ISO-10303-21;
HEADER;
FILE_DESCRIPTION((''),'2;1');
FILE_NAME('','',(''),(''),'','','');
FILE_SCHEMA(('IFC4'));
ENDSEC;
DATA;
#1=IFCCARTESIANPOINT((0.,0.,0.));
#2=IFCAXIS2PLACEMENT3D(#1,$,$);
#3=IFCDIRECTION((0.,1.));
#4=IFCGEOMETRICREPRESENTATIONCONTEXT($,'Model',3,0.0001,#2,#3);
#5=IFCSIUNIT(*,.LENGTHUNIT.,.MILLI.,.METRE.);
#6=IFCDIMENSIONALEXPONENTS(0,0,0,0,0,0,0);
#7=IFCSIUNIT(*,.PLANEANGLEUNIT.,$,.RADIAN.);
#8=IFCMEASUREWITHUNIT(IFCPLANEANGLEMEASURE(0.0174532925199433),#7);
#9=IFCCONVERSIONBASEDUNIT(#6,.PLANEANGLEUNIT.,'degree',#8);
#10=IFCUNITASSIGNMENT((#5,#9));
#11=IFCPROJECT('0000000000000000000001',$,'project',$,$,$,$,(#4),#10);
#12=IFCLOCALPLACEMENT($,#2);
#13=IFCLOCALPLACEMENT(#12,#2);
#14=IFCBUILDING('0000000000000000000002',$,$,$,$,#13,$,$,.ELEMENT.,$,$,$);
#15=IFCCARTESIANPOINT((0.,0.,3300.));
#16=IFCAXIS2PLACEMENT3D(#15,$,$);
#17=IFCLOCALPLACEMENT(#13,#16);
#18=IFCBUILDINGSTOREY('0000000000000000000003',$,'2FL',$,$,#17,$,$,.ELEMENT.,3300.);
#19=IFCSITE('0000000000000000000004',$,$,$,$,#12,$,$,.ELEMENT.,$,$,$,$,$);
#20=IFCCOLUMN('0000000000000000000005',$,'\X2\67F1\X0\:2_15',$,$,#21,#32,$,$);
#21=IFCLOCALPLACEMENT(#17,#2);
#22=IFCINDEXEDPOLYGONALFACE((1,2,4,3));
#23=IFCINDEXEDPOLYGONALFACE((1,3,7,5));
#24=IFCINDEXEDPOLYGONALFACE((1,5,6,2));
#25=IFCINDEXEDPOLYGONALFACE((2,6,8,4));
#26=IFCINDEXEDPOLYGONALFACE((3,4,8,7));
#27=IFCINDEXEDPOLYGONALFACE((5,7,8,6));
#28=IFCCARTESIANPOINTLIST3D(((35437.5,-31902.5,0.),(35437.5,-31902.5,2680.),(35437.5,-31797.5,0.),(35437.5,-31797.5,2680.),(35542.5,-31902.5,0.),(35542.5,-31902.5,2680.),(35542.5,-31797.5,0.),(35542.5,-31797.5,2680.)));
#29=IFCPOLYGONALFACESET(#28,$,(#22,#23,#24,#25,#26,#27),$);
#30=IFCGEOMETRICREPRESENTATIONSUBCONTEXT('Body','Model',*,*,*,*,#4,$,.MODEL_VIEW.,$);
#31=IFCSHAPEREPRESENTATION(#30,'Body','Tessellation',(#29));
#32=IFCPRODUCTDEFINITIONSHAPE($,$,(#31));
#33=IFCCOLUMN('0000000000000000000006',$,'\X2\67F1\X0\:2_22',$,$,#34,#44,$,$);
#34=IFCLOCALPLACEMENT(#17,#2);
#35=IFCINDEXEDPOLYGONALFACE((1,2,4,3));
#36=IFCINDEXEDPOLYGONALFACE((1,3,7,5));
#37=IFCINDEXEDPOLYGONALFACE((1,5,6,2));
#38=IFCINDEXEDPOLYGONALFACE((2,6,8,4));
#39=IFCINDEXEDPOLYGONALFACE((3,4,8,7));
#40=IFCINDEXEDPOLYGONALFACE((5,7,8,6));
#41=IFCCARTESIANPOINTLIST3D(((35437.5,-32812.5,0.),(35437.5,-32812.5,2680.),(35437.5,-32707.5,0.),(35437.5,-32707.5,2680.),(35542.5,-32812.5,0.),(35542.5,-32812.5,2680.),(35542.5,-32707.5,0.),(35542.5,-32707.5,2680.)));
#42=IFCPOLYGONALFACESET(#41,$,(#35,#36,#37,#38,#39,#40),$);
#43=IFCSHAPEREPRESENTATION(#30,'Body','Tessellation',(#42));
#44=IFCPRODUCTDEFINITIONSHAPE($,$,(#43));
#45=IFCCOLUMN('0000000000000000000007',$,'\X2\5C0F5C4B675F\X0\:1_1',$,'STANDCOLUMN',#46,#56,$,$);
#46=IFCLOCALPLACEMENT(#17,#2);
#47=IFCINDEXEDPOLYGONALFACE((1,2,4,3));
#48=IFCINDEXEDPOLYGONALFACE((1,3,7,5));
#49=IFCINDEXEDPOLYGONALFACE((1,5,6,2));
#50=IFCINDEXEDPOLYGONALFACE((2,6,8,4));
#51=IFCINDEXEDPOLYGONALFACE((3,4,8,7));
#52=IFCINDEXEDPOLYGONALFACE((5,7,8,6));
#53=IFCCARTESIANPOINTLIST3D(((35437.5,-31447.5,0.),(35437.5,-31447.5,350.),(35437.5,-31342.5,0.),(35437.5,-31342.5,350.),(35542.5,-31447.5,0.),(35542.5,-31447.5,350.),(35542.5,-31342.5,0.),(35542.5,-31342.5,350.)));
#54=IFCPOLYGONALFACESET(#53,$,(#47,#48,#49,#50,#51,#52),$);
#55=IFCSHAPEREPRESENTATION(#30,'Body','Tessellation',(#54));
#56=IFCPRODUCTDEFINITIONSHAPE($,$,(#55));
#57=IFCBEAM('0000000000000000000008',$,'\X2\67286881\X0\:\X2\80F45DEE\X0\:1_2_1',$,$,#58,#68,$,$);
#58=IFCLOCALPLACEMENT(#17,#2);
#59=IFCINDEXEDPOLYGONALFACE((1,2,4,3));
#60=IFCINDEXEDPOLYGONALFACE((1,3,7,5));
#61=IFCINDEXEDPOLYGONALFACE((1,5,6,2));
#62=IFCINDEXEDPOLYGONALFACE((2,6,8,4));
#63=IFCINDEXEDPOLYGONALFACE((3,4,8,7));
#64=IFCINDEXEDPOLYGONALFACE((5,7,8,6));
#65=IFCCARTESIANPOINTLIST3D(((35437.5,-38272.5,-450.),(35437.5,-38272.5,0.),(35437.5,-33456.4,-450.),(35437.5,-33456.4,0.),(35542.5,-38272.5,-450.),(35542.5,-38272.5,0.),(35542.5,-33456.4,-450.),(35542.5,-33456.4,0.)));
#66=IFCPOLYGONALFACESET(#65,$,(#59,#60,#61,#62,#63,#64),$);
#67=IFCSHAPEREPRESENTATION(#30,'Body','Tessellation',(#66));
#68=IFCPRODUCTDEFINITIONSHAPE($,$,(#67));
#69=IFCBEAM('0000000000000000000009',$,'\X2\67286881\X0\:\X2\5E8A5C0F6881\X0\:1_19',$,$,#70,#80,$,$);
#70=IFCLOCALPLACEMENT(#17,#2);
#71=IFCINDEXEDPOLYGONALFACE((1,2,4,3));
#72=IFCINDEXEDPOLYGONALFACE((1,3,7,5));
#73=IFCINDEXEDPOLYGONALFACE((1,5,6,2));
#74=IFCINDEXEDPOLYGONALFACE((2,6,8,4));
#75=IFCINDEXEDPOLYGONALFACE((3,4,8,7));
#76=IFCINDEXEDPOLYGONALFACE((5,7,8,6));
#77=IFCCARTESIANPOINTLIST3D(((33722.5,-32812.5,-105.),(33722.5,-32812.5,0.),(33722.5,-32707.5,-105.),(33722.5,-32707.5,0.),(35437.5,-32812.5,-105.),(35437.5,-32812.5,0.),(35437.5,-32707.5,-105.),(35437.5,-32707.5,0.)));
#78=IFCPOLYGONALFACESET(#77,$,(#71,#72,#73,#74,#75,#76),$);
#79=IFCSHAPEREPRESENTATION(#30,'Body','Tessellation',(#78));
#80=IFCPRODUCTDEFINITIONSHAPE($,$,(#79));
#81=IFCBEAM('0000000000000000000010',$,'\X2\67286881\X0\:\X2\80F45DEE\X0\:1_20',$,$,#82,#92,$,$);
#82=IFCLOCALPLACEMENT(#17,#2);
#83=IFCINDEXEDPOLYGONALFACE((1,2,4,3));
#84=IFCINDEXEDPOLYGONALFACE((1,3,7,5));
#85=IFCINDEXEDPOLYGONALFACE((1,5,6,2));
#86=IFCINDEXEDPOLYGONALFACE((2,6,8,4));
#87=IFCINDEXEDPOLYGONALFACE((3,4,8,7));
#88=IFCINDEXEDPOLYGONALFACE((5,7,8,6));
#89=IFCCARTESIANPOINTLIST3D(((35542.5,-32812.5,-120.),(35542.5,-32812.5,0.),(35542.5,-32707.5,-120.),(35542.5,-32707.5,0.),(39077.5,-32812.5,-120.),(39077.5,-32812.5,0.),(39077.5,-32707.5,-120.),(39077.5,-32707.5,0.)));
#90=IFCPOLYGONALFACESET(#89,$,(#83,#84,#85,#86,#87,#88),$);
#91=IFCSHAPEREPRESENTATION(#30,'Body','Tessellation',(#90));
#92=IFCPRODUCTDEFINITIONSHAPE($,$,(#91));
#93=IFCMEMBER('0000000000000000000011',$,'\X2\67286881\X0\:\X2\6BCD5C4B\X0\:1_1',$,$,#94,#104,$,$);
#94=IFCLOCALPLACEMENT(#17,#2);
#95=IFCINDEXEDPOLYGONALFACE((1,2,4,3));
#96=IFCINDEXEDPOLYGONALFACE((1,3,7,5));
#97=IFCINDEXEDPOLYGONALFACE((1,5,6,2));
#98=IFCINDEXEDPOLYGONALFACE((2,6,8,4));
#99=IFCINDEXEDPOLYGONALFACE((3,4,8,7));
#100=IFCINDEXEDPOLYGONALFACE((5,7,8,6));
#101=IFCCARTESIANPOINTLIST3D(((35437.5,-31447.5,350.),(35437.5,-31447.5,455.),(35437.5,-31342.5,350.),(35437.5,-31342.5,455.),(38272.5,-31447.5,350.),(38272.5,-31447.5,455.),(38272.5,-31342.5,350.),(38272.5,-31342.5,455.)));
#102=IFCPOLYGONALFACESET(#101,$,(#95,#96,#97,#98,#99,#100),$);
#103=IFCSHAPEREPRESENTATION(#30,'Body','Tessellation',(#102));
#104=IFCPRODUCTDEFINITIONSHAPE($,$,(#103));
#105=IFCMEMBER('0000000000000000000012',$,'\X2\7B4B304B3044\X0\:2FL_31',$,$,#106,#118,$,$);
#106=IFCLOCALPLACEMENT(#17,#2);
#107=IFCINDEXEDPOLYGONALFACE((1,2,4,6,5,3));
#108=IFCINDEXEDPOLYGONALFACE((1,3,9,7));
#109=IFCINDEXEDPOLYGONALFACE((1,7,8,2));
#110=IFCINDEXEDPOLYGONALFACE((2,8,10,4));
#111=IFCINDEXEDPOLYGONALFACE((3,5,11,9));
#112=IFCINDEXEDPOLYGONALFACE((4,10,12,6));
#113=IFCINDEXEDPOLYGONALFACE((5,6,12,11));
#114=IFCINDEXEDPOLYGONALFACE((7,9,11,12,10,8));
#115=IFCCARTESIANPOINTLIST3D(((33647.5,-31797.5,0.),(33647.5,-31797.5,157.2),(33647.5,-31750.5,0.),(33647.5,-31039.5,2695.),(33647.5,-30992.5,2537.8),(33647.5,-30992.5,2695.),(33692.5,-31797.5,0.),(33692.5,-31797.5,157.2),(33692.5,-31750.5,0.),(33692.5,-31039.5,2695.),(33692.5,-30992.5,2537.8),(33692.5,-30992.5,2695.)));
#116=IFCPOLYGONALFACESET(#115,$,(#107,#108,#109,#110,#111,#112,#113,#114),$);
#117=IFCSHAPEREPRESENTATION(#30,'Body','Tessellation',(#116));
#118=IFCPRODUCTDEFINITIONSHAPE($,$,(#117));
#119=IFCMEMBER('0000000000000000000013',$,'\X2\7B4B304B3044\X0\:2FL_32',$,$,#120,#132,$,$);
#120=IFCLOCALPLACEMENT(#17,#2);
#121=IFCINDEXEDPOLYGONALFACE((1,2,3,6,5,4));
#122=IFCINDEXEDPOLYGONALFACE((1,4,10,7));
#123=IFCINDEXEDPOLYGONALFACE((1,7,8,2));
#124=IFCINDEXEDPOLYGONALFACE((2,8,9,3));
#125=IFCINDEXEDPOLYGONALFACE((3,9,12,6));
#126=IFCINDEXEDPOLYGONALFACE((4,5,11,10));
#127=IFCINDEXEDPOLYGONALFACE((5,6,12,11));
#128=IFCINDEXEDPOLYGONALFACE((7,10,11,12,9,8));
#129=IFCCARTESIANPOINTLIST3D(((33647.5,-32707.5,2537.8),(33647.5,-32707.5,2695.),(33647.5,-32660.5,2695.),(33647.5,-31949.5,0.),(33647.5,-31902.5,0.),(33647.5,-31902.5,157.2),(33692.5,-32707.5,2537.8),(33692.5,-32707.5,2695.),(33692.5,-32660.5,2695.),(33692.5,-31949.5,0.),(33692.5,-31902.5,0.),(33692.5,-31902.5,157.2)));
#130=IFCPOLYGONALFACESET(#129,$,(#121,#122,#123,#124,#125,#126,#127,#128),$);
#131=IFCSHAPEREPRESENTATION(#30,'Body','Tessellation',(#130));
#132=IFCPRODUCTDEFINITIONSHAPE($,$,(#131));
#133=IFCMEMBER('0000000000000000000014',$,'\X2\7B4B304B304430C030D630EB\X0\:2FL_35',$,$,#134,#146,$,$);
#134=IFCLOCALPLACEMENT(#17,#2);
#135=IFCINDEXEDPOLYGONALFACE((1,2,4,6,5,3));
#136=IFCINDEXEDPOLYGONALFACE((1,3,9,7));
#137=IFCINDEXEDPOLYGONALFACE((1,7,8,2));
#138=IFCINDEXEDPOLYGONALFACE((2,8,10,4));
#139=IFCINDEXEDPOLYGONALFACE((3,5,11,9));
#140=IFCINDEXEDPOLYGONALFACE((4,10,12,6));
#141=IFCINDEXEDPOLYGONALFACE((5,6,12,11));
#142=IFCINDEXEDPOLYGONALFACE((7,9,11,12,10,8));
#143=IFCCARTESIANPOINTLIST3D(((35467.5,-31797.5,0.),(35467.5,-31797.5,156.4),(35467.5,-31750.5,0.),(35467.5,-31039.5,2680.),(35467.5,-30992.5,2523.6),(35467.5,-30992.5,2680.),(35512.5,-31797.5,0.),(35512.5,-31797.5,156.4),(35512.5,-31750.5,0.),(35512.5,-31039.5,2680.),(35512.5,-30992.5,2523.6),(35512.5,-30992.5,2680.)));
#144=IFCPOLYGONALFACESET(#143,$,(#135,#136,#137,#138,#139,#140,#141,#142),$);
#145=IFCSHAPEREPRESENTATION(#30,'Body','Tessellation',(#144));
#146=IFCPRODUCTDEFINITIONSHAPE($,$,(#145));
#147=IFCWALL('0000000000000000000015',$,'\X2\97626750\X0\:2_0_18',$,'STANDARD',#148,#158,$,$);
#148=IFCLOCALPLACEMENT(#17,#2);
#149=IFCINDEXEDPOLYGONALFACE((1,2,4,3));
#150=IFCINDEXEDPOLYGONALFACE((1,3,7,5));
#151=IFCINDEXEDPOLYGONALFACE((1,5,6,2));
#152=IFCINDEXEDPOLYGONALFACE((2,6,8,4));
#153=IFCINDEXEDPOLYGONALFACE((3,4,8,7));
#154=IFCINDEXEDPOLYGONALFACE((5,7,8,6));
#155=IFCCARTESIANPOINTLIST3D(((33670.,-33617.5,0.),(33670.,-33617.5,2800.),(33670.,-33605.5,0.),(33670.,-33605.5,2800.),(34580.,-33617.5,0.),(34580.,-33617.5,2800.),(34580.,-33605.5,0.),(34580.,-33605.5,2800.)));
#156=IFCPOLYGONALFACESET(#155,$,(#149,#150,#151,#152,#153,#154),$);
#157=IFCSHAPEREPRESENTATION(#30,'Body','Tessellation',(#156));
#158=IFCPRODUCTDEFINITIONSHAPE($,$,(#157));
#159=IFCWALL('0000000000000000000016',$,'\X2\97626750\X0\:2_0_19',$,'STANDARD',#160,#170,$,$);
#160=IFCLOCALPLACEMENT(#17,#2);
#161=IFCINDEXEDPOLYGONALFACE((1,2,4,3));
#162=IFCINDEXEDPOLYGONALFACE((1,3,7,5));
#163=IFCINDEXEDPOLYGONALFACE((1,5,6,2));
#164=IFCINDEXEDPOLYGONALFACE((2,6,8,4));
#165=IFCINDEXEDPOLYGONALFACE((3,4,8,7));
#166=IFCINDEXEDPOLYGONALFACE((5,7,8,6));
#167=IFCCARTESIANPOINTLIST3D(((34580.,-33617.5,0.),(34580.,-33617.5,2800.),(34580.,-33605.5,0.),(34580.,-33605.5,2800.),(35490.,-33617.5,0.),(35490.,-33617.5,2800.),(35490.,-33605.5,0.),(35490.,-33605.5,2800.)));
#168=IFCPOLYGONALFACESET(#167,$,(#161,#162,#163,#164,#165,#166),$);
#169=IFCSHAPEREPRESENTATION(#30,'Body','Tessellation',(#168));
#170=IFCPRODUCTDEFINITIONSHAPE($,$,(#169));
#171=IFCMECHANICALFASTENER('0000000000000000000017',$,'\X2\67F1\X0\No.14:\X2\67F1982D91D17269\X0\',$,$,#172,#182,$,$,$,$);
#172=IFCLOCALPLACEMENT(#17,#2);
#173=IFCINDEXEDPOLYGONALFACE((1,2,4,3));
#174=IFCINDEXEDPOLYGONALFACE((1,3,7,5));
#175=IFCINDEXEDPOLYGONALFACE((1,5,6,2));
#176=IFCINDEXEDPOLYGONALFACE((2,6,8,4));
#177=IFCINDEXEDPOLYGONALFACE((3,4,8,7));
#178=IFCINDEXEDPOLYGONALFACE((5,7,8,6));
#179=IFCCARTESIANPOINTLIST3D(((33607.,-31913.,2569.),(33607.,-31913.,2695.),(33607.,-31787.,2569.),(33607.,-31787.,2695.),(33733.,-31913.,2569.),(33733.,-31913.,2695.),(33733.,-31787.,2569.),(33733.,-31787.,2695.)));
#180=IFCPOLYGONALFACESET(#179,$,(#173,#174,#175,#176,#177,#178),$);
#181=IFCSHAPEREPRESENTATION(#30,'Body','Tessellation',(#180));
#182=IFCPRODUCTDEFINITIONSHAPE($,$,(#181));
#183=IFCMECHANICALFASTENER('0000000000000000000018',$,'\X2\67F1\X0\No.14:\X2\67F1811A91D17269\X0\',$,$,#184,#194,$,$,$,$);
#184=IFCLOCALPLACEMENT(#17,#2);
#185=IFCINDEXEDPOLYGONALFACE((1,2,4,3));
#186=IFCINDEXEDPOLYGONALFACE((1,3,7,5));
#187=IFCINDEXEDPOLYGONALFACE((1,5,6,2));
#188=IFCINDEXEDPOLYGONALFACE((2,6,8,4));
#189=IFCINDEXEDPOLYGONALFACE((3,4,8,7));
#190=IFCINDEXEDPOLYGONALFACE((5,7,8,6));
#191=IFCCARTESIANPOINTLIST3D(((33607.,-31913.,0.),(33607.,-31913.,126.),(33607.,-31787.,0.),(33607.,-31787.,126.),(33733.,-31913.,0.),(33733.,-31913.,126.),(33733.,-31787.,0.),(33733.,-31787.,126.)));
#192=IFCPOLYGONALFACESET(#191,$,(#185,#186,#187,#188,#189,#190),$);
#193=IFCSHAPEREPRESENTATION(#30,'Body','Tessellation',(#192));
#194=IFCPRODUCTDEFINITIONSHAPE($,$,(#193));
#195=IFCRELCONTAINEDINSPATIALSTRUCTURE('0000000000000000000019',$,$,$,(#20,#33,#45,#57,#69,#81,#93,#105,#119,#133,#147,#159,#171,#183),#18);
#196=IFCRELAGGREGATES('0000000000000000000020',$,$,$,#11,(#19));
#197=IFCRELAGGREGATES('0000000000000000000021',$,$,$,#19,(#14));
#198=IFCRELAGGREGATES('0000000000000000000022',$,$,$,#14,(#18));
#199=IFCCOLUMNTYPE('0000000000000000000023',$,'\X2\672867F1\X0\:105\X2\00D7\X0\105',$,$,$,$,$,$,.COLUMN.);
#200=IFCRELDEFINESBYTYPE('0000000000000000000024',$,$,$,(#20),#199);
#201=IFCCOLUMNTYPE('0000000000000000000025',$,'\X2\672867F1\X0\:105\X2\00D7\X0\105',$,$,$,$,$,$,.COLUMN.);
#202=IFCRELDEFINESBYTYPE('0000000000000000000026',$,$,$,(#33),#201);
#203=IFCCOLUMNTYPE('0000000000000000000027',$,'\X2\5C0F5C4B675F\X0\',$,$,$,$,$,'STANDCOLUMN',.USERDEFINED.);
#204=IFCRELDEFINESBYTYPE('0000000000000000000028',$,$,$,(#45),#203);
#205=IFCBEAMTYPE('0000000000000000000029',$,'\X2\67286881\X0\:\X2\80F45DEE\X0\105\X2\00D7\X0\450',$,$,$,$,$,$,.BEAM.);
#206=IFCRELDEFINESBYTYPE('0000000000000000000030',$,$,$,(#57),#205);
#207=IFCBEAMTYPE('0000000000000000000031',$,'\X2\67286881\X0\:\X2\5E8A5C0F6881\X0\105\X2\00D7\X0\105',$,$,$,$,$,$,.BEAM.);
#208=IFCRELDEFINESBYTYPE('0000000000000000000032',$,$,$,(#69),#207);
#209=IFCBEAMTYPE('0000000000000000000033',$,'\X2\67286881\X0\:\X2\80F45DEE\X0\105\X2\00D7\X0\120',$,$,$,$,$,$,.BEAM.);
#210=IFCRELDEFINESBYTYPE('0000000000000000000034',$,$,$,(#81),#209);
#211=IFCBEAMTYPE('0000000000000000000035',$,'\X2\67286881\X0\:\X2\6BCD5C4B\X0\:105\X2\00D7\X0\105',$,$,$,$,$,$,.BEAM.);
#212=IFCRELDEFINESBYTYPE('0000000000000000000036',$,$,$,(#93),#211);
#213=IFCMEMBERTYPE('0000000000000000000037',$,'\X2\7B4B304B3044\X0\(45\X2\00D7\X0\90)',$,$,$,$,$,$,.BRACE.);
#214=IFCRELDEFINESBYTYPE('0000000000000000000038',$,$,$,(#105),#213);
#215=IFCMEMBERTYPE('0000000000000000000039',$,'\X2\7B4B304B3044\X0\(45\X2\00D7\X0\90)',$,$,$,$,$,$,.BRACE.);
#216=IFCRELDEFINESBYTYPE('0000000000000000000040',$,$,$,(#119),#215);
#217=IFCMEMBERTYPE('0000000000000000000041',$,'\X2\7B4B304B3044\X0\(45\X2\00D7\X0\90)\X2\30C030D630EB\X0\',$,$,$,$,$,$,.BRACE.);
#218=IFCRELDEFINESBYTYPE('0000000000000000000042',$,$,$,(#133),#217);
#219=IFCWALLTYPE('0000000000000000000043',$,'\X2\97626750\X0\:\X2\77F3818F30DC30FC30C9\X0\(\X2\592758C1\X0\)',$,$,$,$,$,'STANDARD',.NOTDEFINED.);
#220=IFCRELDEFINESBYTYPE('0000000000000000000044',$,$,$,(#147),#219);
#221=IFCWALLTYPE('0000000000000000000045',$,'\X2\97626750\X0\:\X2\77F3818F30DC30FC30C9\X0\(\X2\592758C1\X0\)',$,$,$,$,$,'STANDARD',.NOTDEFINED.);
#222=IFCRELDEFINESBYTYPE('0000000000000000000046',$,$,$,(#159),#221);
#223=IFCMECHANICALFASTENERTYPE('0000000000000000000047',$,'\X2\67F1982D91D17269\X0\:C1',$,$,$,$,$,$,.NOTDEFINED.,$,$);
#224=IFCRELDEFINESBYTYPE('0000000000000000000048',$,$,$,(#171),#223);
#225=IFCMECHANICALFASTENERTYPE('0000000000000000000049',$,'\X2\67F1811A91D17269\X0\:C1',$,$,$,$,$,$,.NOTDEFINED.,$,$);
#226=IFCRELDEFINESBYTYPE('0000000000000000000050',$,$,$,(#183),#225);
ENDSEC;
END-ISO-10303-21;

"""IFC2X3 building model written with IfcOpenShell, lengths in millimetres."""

from ifc_helpers import new_model, entity, si_unit, converted_unit, direction, frame, origin, origin_with_axes, origin_2d, place, context, subcontext, project, spatial, polyline, rectangle, outline, extrude, type_object, element, save


model = new_model("IFC2X3")

# Units and contexts
model_context = context("Model", 3, precision=0.0001, world=origin(), true_north=direction((0.0, 1.0)))
body_context = subcontext(model_context, "Body", "Model", "MODEL_VIEW")
ifc_project = project(units=[si_unit("LENGTHUNIT", "METRE", prefix="MILLI"), converted_unit("PLANEANGLEUNIT", "degree", entity("IfcPlaneAngleMeasure", 0.0174532925199433), si_unit("PLANEANGLEUNIT", "RADIAN"), dimensions=[0, 0, 0, 0, 0, 0, 0])], contexts=[model_context])

# Site, building, storey
site_placement = place(None, origin())
site = spatial("IfcSite", under=ifc_project, at=site_placement, CompositionType="ELEMENT")
building_placement = place(site_placement, origin())
building = spatial("IfcBuilding", under=site, at=building_placement, CompositionType="ELEMENT")
storey_placement = place(building_placement, frame((0.0, 0.0, 3300.0)))
storey = spatial("IfcBuildingStorey", under=building, at=storey_placement, Name="2FL", CompositionType="ELEMENT", Elevation=3300.0)

# Columns
column_type_1 = type_object("IfcColumnType", Name="木柱:105×105", PredefinedType="COLUMN")
column_1_placement = place(storey_placement, frame((35490.0, -31850.0, 0.0)))
element("IfcColumn", 1, at=column_1_placement, inside=storey, type_object=column_type_1, Name="柱:2_15", context=body_context, shape_type="SweptSolid", body=[
    extrude(rectangle(XDim=105.0, YDim=105.0, at=origin_2d()), origin_with_axes(), (0.0, 0.0, 1.0), 2680.0),
])
column_type_2 = type_object("IfcColumnType", Name="木柱:105×105", PredefinedType="COLUMN")
column_2_placement = place(storey_placement, frame((35490.0, -32760.0, 0.0)))
element("IfcColumn", 2, at=column_2_placement, inside=storey, type_object=column_type_2, Name="柱:2_22", context=body_context, shape_type="SweptSolid", body=[
    extrude(rectangle(XDim=105.0, YDim=105.0, at=origin_2d()), origin_with_axes(), (0.0, 0.0, 1.0), 2680.0),
])
column_type_3 = type_object("IfcColumnType", Name="小屋束", ElementType="STANDCOLUMN", PredefinedType="USERDEFINED")
column_3_placement = place(storey_placement, frame((35490.0, -31395.0, 0.0)))
element("IfcColumn", 3, at=column_3_placement, inside=storey, type_object=column_type_3, Name="小屋束:1_1", ObjectType="STANDCOLUMN", context=body_context, shape_type="SweptSolid", body=[
    extrude(rectangle(XDim=105.0, YDim=105.0, at=origin_2d()), origin_with_axes(), (0.0, 0.0, 1.0), 350.0),
])

# Beams
beam_type_1 = type_object("IfcBeamType", Name="木梁:胴差105×450", PredefinedType="BEAM")
beam_1_placement = place(storey_placement, frame((35490.0, -33456.3, -225.0), z_axis=(0.0, -1.0, 0.0), x_axis=(1.0, 0.0, 0.0)))
element("IfcBeam", 4, at=beam_1_placement, inside=storey, type_object=beam_type_1, Name="木梁:胴差:1_2_1", context=body_context, shape_type="SweptSolid", body=[
    extrude(rectangle(XDim=105.0, YDim=450.0, at=origin_2d()), origin_with_axes(), (0.0, 0.0, 1.0), 4816.1),
])
beam_type_2 = type_object("IfcBeamType", Name="木梁:床小梁105×105", PredefinedType="BEAM")
beam_2_placement = place(storey_placement, frame((33722.5, -32760.0, -52.5), z_axis=(1.0, 0.0, 0.0), x_axis=(0.0, 1.0, 0.0)))
element("IfcBeam", 5, at=beam_2_placement, inside=storey, type_object=beam_type_2, Name="木梁:床小梁:1_19", context=body_context, shape_type="SweptSolid", body=[
    extrude(rectangle(XDim=105.0, YDim=105.0, at=origin_2d()), origin_with_axes(), (0.0, 0.0, 1.0), 1715.0),
])
beam_type_3 = type_object("IfcBeamType", Name="木梁:胴差105×120", PredefinedType="BEAM")
beam_3_placement = place(storey_placement, frame((35542.5, -32760.0, -60.0), z_axis=(1.0, 0.0, 0.0), x_axis=(0.0, 1.0, 0.0)))
element("IfcBeam", 6, at=beam_3_placement, inside=storey, type_object=beam_type_3, Name="木梁:胴差:1_20", context=body_context, shape_type="SweptSolid", body=[
    extrude(rectangle(XDim=105.0, YDim=120.0, at=origin_2d()), origin_with_axes(), (0.0, 0.0, 1.0), 3535.0),
])

# Members
beam_type_4 = type_object("IfcBeamType", Name="木梁:母屋:105×105", PredefinedType="BEAM")
member_1_placement = place(storey_placement, frame((35437.5, -31395.0, 402.5), z_axis=(1.0, 0.0, 0.0), x_axis=(0.0, -1.0, 0.0)))
element("IfcMember", 7, at=member_1_placement, inside=storey, type_object=beam_type_4, Name="木梁:母屋:1_1", context=body_context, shape_type="SweptSolid", body=[
    extrude(rectangle(XDim=105.0, YDim=105.0, at=origin_2d()), origin_with_axes(), (0.0, 0.0, 1.0), 2835.0),
])
member_type_1 = type_object("IfcMemberType", Name="筋かい(45×90)", PredefinedType="BRACE")
member_2_placement = place(storey_placement, frame((33670.0, -31797.5, 0.0), z_axis=(0.0, 0.286206, 0.958168), x_axis=(0.0, -0.958168, 0.286206)))
element("IfcMember", 8, at=member_2_placement, inside=storey, type_object=member_type_1, Name="筋かい:2FL_31", context=body_context, shape_type="SweptSolid", body=[
    extrude(outline(polyline([(0.0, 0.0), (13.4, -45.0), (2662.0, -45.0), (2812.7, 0.0), (2799.2, 45.0), (150.7, 45.0), (0.0, 0.0)])), frame((0.0, -22.5, 0.0), z_axis=(0.0, 1.0, 0.0), x_axis=(0.0, 0.0, 1.0)), (0.0, 0.0, 1.0), 45.0),
])
member_type_2 = type_object("IfcMemberType", Name="筋かい(45×90)", PredefinedType="BRACE")
member_3_placement = place(storey_placement, frame((33670.0, -31902.5, 0.0), z_axis=(0.0, -0.286206, 0.958168), x_axis=(0.0, 0.958168, 0.286206)))
element("IfcMember", 9, at=member_3_placement, inside=storey, type_object=member_type_2, Name="筋かい:2FL_32", context=body_context, shape_type="SweptSolid", body=[
    extrude(outline(polyline([(0.0, 0.0), (13.4, -45.0), (2662.0, -45.0), (2812.7, 0.0), (2799.2, 45.0), (150.7, 45.0), (0.0, 0.0)])), frame((0.0, -22.5, 0.0), z_axis=(0.0, 1.0, 0.0), x_axis=(0.0, 0.0, 1.0)), (0.0, 0.0, 1.0), 45.0),
])
member_type_3 = type_object("IfcMemberType", Name="筋かい(45×90)ダブル", PredefinedType="BRACE")
member_4_placement = place(storey_placement, frame((35490.0, -31797.5, 0.0), z_axis=(0.0, 0.287676, 0.957728), x_axis=(0.0, -0.957728, 0.287676)))
element("IfcMember", 10, at=member_4_placement, inside=storey, type_object=member_type_3, Name="筋かいダブル:2FL_35", context=body_context, shape_type="SweptSolid", body=[
    extrude(outline(polyline([(0.0, 0.0), (13.5, -45.0), (2648.5, -45.0), (2798.3, 0.0), (2784.8, 45.0), (149.8, 45.0), (0.0, 0.0)])), frame((0.0, -22.5, 0.0), z_axis=(0.0, 1.0, 0.0), x_axis=(0.0, 0.0, 1.0)), (0.0, 0.0, 1.0), 45.0),
])

# Walls
wall_type_1 = type_object("IfcWallType", Name="面材:石膏ボード(大壁)", ElementType="STANDARD", PredefinedType="NOTDEFINED")
wall_1_placement = place(storey_placement, frame((34125.0, -33605.5, 0.0), z_axis=(0.0, -1.0, 0.0), x_axis=(1.0, 0.0, 0.0)))
element("IfcWall", 11, at=wall_1_placement, inside=storey, type_object=wall_type_1, Name="面材:2_0_18", ObjectType="STANDARD", context=body_context, shape_type="SweptSolid", body=[
    extrude(outline(polyline([(455.0, 0.0, 0.0), (-455.0, 0.0, 0.0), (-455.0, 2800.0, 0.0), (455.0, 2800.0, 0.0), (455.0, 0.0, 0.0)])), origin_with_axes(), (0.0, 0.0, 1.0), 12.0),
])
wall_type_2 = type_object("IfcWallType", Name="面材:石膏ボード(大壁)", ElementType="STANDARD", PredefinedType="NOTDEFINED")
wall_2_placement = place(storey_placement, frame((35035.0, -33605.5, 0.0), z_axis=(0.0, -1.0, 0.0), x_axis=(1.0, 0.0, 0.0)))
element("IfcWall", 12, at=wall_2_placement, inside=storey, type_object=wall_type_2, Name="面材:2_0_19", ObjectType="STANDARD", context=body_context, shape_type="SweptSolid", body=[
    extrude(outline(polyline([(455.0, 0.0, 0.0), (-455.0, 0.0, 0.0), (-455.0, 2800.0, 0.0), (455.0, 2800.0, 0.0), (455.0, 0.0, 0.0)])), origin_with_axes(), (0.0, 0.0, 1.0), 12.0),
])

# Mechanical fasteners
mechanical_fastener_type_1 = type_object("IfcMechanicalFastenerType", Name="柱頭金物:C1")
mechanical_fastener_1_placement = place(storey_placement, frame((33670.0, -31850.0, 2569.0)))
element("IfcMechanicalFastener", 13, at=mechanical_fastener_1_placement, inside=storey, type_object=mechanical_fastener_type_1, Name="柱No.14:柱頭金物", context=body_context, shape_type="SweptSolid", body=[
    extrude(rectangle(XDim=126.0, YDim=126.0, at=origin_2d()), origin_with_axes(), (0.0, 0.0, 1.0), 126.0),
])
mechanical_fastener_type_2 = type_object("IfcMechanicalFastenerType", Name="柱脚金物:C1")
mechanical_fastener_2_placement = place(storey_placement, frame((33670.0, -31850.0, 0.0)))
element("IfcMechanicalFastener", 14, at=mechanical_fastener_2_placement, inside=storey, type_object=mechanical_fastener_type_2, Name="柱No.14:柱脚金物", context=body_context, shape_type="SweptSolid", body=[
    extrude(rectangle(XDim=126.0, YDim=126.0, at=origin_2d()), origin_with_axes(), (0.0, 0.0, 1.0), 126.0),
])

save(model, "model.ifc")
